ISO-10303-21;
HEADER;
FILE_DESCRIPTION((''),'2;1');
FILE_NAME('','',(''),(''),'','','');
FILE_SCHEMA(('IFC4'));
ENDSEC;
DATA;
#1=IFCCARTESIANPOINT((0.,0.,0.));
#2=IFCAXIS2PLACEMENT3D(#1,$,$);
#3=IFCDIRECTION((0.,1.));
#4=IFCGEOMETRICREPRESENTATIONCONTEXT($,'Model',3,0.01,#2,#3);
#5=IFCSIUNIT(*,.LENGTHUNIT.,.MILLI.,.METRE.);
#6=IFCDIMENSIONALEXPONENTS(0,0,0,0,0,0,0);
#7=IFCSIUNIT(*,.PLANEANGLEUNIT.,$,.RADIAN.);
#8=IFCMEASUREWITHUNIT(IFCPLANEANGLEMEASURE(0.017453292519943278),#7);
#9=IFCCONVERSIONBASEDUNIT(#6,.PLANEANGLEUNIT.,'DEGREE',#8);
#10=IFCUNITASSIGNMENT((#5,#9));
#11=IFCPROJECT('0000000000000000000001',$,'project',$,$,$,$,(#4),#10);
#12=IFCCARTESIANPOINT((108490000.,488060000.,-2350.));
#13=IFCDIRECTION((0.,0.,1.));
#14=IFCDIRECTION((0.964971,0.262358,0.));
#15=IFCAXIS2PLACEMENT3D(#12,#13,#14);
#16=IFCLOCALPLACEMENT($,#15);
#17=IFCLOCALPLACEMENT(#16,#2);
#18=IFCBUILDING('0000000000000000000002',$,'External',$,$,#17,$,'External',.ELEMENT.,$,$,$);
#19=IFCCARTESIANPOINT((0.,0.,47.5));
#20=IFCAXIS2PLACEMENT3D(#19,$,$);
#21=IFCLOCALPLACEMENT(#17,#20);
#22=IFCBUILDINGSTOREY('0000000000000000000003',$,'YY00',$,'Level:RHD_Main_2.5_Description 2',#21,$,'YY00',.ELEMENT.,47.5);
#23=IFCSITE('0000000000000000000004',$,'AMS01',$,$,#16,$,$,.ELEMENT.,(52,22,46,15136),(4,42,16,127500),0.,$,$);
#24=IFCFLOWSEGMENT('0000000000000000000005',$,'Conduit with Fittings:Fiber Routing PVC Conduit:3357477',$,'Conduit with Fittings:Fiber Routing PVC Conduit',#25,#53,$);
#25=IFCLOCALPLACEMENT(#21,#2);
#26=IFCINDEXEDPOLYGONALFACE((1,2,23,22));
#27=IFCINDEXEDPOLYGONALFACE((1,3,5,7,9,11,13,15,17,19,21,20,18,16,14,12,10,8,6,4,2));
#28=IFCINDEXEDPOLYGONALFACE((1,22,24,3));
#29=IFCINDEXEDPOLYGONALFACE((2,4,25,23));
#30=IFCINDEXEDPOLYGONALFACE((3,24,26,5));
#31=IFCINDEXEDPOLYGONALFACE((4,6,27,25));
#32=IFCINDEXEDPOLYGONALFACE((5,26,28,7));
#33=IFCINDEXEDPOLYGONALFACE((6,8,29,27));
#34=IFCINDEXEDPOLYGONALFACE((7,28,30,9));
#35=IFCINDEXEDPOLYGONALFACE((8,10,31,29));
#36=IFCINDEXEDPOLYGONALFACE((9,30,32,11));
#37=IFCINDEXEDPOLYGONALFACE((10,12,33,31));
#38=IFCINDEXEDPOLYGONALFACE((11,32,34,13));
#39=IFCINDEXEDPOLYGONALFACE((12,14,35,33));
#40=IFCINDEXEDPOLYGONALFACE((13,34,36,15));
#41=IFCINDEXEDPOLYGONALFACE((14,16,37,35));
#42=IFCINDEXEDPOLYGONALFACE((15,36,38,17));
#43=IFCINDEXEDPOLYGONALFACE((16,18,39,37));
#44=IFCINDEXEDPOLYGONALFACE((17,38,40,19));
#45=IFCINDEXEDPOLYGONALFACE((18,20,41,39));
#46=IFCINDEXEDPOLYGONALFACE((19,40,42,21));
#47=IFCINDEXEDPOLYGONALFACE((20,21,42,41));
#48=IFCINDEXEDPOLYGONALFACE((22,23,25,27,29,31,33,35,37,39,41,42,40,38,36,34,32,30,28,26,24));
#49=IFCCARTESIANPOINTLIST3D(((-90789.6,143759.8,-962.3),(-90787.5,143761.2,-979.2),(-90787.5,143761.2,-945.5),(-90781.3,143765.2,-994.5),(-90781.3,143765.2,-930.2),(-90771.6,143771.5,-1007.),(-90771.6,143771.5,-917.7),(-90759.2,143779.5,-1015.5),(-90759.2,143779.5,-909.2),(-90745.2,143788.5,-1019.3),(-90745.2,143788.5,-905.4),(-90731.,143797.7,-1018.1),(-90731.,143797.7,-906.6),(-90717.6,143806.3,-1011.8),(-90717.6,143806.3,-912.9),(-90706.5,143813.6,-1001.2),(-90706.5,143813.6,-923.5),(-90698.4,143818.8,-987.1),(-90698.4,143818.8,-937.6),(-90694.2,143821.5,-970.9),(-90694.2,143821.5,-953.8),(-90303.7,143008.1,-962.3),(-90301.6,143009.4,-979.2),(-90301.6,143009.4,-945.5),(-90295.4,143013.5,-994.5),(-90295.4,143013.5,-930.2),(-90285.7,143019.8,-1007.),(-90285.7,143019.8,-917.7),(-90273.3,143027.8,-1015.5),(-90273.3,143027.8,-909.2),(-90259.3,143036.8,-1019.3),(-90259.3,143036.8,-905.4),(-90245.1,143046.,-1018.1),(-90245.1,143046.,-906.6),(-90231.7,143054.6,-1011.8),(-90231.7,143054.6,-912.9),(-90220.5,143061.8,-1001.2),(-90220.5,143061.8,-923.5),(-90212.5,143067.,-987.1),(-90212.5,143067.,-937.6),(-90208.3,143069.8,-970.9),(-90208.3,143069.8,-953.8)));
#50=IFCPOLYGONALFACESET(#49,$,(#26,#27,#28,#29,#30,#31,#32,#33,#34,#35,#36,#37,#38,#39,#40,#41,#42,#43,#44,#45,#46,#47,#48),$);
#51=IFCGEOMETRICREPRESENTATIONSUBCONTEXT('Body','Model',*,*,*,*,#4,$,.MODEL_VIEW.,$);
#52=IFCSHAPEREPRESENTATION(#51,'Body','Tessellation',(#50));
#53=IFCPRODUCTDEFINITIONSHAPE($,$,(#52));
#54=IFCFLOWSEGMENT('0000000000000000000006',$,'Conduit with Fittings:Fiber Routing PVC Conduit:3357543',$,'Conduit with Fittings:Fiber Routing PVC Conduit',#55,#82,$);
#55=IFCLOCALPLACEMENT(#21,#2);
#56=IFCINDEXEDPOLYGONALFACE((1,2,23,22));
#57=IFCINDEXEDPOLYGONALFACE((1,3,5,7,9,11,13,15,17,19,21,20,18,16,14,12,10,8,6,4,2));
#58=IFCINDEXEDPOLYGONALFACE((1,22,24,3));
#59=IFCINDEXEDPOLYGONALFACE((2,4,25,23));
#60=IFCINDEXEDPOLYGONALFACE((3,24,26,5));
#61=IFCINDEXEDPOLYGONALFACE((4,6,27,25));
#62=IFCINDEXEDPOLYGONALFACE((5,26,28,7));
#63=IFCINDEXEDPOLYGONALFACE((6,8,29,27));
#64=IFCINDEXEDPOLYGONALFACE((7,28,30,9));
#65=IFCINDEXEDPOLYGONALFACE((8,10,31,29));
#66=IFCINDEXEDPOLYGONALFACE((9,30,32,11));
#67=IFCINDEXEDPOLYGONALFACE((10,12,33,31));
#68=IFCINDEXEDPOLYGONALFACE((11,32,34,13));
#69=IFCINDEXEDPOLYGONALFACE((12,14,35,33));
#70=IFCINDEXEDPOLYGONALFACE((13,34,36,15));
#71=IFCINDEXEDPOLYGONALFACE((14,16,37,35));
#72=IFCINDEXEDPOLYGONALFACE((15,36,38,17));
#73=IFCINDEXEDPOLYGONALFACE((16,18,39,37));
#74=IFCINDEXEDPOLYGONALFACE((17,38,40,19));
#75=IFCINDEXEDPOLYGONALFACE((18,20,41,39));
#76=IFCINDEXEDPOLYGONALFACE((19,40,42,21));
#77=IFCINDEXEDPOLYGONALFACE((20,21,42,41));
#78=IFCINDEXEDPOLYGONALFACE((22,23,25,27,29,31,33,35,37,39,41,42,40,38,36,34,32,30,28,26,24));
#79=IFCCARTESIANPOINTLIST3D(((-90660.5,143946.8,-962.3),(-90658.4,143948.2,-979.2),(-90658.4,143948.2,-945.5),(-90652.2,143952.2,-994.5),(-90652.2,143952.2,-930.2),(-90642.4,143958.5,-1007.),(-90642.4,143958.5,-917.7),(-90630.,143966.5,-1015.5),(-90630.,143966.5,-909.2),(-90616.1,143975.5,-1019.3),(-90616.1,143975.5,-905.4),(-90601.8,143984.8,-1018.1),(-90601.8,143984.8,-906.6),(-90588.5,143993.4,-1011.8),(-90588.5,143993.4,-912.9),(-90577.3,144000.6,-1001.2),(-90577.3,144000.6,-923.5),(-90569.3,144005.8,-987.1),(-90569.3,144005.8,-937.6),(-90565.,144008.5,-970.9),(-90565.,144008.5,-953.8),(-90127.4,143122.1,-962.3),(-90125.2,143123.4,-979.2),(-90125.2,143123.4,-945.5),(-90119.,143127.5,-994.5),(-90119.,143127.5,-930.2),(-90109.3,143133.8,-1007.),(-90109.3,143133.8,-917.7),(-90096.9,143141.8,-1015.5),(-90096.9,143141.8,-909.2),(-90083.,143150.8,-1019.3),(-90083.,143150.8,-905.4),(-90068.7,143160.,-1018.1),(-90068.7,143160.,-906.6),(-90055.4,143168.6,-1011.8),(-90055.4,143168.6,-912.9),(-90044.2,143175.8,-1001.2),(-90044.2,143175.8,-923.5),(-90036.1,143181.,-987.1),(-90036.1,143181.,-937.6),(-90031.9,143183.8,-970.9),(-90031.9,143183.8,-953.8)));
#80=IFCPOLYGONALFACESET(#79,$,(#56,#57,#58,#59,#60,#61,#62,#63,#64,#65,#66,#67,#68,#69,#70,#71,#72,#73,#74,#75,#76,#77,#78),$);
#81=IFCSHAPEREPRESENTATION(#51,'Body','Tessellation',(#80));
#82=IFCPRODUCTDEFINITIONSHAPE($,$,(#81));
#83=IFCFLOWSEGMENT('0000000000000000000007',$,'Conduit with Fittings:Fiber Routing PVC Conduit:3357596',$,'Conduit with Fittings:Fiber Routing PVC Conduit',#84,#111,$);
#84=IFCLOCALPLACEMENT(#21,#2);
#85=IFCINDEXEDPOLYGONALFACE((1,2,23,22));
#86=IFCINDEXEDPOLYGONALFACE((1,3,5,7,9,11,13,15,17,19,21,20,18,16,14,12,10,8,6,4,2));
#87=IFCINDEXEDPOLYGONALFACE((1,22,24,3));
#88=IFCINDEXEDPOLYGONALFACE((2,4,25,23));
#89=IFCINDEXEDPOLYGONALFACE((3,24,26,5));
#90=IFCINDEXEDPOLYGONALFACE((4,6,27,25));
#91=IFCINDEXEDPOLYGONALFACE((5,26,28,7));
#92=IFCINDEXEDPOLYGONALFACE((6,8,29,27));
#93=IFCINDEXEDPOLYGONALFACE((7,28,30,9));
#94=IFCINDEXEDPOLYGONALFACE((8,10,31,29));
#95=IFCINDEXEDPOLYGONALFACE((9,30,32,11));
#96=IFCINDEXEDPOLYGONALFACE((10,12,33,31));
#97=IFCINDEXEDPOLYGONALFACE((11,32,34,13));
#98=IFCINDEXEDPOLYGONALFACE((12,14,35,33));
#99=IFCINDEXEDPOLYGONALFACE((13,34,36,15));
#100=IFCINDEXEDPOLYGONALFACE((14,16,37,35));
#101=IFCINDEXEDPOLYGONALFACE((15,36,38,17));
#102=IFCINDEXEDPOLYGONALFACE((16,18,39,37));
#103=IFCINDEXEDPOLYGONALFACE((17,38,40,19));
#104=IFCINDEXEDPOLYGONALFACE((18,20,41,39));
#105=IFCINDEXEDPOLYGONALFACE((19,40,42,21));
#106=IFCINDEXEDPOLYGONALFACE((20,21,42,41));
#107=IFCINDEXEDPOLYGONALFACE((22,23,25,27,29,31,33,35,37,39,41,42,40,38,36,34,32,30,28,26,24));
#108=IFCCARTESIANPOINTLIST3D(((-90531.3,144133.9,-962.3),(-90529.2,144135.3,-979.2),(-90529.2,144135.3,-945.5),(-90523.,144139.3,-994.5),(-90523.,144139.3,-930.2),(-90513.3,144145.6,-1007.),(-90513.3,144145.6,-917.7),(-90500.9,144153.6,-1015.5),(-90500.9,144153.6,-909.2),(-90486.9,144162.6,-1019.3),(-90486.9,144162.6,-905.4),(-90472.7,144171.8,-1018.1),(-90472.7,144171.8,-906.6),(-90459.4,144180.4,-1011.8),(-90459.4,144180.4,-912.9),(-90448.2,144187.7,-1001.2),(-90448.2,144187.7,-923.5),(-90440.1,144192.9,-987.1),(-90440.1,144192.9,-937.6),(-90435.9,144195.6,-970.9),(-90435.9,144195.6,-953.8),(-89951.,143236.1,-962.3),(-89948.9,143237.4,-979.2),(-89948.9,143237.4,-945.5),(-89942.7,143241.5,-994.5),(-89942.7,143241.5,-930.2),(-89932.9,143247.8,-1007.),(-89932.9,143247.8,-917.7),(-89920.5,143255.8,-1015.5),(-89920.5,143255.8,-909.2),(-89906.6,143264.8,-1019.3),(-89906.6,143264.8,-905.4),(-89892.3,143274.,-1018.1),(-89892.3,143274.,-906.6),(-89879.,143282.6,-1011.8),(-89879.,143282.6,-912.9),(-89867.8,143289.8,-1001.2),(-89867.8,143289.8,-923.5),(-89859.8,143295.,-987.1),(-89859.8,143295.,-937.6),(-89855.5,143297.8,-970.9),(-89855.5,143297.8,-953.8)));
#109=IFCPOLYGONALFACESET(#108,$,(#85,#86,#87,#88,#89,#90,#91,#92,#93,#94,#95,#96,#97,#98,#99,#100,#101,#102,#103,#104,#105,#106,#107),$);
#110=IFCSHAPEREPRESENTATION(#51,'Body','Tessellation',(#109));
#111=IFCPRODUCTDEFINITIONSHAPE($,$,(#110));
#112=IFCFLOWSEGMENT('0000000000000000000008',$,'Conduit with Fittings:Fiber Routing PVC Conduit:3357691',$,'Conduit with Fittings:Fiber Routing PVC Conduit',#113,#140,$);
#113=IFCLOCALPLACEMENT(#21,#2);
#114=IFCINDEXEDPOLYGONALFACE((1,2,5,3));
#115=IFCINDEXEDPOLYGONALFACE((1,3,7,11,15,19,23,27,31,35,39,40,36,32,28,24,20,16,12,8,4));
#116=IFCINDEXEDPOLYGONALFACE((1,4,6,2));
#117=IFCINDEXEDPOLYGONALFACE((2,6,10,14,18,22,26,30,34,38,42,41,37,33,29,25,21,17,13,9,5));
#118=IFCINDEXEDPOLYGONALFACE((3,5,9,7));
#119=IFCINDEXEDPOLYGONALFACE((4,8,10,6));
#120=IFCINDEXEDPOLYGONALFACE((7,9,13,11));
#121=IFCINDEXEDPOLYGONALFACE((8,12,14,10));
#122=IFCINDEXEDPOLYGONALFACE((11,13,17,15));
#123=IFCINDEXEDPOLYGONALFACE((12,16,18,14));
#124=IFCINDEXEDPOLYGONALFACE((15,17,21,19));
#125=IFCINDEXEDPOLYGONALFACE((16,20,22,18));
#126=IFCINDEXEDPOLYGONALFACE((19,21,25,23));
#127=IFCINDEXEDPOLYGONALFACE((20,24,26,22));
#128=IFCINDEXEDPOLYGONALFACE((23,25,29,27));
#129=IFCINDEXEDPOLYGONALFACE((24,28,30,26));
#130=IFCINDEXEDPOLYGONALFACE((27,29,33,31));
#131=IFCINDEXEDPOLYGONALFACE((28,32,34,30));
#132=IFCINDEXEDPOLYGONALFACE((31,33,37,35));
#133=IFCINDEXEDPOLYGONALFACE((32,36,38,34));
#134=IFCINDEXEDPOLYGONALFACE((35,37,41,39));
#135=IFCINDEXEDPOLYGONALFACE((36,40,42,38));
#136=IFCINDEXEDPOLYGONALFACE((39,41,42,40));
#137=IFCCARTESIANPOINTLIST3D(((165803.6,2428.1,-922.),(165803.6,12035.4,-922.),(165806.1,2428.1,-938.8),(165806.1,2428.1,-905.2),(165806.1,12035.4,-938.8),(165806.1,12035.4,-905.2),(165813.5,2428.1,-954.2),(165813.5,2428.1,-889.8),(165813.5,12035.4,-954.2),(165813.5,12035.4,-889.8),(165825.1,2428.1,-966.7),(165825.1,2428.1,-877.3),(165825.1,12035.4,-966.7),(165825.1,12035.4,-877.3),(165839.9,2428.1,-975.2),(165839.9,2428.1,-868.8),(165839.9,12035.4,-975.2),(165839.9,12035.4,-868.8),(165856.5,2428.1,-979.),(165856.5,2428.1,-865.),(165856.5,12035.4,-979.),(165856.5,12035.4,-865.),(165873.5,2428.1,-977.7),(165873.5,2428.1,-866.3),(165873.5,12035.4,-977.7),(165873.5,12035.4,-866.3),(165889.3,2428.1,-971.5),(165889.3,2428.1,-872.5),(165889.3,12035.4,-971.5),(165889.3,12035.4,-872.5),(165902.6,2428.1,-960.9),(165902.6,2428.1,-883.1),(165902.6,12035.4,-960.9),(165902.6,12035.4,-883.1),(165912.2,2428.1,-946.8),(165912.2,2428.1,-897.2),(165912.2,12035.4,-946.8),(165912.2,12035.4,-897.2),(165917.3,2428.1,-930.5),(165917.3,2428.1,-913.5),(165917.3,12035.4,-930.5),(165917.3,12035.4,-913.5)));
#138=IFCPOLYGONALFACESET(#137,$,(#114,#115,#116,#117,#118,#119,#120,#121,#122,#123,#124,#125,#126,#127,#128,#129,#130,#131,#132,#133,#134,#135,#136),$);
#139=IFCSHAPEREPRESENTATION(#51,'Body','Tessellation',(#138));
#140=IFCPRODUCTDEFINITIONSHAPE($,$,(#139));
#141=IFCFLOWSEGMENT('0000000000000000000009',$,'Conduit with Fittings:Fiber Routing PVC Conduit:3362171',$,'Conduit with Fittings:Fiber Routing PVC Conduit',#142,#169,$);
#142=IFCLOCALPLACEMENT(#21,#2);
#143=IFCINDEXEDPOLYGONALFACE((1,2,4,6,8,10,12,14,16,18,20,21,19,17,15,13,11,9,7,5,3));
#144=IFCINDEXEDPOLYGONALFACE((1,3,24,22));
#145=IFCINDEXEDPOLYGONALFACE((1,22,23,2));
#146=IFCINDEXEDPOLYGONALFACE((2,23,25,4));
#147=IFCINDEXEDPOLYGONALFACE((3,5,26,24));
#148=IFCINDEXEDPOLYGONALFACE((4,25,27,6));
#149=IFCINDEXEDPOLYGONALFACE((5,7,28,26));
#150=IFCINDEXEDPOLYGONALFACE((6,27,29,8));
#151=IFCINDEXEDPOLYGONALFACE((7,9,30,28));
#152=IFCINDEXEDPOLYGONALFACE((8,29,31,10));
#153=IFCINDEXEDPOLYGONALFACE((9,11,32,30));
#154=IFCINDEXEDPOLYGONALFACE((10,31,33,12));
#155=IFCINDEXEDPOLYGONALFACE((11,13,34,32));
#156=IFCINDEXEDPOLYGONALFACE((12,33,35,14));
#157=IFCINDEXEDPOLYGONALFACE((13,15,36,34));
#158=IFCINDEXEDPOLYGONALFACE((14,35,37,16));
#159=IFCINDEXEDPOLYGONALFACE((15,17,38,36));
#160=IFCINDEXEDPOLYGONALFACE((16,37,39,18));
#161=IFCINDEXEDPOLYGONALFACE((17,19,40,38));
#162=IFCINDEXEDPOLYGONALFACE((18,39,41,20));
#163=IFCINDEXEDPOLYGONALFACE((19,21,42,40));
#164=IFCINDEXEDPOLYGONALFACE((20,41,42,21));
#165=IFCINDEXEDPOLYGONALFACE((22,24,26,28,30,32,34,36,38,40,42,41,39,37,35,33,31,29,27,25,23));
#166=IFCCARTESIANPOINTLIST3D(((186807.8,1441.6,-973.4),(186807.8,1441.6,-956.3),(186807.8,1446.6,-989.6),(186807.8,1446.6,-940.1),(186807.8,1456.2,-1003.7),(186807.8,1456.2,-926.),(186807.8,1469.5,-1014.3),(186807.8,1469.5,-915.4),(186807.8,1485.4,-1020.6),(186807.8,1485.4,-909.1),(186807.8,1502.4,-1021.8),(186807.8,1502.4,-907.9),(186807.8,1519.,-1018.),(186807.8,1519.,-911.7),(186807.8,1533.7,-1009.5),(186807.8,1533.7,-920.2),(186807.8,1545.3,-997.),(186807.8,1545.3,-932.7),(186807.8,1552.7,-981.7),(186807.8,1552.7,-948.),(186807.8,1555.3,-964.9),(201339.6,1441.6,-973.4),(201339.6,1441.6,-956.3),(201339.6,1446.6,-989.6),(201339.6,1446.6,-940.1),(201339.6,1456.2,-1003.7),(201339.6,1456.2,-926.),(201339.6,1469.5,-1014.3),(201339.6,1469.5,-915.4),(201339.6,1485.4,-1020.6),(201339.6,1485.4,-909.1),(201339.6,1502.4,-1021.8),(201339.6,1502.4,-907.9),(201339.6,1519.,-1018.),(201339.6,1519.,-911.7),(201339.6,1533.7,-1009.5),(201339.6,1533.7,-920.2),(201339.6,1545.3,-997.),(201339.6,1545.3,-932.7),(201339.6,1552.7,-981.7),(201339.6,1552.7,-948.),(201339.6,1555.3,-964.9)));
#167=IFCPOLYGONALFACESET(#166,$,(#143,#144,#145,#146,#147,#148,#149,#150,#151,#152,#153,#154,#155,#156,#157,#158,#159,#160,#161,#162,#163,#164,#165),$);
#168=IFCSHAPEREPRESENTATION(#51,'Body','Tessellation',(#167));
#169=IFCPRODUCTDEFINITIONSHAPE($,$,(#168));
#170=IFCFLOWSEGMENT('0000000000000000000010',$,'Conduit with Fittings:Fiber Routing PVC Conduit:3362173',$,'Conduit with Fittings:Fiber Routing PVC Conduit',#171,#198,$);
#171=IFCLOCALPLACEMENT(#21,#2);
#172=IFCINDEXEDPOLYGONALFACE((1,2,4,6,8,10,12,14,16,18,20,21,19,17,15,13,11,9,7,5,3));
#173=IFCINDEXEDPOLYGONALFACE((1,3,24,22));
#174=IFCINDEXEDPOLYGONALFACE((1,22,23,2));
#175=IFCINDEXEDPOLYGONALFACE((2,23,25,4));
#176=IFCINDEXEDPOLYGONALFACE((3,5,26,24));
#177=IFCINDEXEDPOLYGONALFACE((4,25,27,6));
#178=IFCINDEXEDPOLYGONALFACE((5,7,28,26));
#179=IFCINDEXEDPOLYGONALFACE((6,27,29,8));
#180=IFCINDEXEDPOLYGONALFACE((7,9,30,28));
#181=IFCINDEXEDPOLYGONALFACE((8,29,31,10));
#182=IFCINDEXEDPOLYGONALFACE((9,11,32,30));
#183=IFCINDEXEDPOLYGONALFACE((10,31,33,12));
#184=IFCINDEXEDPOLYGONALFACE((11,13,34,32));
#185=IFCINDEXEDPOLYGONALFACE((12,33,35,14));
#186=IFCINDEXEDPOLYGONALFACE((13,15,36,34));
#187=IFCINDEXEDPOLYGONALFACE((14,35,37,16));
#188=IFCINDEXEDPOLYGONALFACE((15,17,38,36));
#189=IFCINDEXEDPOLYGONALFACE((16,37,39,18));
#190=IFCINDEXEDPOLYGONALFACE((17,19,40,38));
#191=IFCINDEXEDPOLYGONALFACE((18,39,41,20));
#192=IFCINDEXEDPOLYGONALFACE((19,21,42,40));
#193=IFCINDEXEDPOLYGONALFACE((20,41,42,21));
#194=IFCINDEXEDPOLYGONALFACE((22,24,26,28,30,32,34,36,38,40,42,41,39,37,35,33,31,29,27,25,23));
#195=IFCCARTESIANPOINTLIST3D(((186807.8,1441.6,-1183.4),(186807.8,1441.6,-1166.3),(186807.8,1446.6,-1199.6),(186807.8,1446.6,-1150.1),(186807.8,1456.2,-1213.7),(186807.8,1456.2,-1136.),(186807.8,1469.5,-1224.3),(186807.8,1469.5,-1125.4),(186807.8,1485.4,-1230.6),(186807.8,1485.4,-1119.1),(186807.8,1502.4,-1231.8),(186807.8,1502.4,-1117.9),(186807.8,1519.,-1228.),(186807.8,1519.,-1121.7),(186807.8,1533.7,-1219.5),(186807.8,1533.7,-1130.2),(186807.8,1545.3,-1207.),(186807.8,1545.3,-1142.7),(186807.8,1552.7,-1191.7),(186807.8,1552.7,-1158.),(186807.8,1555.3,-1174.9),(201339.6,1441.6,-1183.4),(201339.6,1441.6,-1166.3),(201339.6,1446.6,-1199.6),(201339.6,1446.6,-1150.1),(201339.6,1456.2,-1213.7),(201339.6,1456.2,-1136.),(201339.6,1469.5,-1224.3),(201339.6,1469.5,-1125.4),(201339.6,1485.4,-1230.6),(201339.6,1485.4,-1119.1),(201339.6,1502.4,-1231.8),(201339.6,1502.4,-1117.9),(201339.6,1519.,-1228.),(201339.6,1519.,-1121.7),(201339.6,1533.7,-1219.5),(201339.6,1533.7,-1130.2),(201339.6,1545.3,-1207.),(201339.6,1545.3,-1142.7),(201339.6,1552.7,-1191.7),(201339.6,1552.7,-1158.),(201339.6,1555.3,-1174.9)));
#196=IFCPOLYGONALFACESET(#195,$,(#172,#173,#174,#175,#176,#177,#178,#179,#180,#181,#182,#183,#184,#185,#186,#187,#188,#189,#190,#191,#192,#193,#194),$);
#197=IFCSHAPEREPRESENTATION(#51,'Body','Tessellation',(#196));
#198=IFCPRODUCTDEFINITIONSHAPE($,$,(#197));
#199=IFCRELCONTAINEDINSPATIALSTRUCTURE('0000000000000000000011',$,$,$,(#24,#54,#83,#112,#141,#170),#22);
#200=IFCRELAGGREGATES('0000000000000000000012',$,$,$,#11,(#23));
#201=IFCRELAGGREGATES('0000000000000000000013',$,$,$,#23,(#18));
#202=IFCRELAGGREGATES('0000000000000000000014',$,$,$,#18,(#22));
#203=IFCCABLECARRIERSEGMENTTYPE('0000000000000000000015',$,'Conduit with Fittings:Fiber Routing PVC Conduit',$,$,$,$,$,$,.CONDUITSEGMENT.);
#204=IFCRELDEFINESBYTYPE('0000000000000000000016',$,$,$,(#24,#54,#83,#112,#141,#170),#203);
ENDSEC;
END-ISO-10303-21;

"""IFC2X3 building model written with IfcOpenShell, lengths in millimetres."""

from ifc_helpers import new_model, entity, si_unit, converted_unit, direction, frame, frame_2d, origin, place, context, subcontext, project, spatial, circle, extrude, type_object, element, save


model = new_model("IFC2X3")

# Units and contexts
model_context = context("Model", 3, precision=0.01, world=origin(), true_north=direction((0.0, 1.0)))
body_context = subcontext(model_context, "Body", "Model", "MODEL_VIEW")
ifc_project = project(units=[si_unit("LENGTHUNIT", "METRE", prefix="MILLI"), converted_unit("PLANEANGLEUNIT", "DEGREE", entity("IfcPlaneAngleMeasure", 0.017453292519943278), si_unit("PLANEANGLEUNIT", "RADIAN"), dimensions=[0, 0, 0, 0, 0, 0, 0])], contexts=[model_context])

# Site, building, storey
site_placement = place(None, frame((108490000.0, 488060000.0, -2350.0), z_axis=(0.0, 0.0, 1.0), x_axis=(0.964971, 0.262358, 0.0)))
site = spatial("IfcSite", under=ifc_project, at=site_placement, Name="AMS01", CompositionType="ELEMENT", RefLatitude=(52, 22, 46, 15136), RefLongitude=(4, 42, 16, 127500), RefElevation=0.0)
building_placement = place(site_placement, origin())
building = spatial("IfcBuilding", under=site, at=building_placement, Name="External", LongName="External", CompositionType="ELEMENT")
storey_placement = place(building_placement, frame((0.0, 0.0, 47.5)))
storey = spatial("IfcBuildingStorey", under=building, at=storey_placement, Name="YY00", ObjectType="Level:RHD_Main_2.5_Description 2", LongName="YY00", CompositionType="ELEMENT", Elevation=47.5)

# Flow segments
cable_carrier_segment_type = type_object("IfcCableCarrierSegmentType", Name="Conduit with Fittings:Fiber Routing PVC Conduit", PredefinedType="CONDUITSEGMENT")
flow_segment_1_placement = place(storey_placement, origin())
element("IfcFlowSegment", 1, at=flow_segment_1_placement, inside=storey, type_object=cable_carrier_segment_type, Name="Conduit with Fittings:Fiber Routing PVC Conduit:3357477", ObjectType="Conduit with Fittings:Fiber Routing PVC Conduit", context=body_context, shape_type="SweptSolid", body=[
    extrude(circle(Radius=57.2, at=frame_2d((0.0, 0.0), x_axis=(1.0, 0.0))), frame((-90741.6, 143790.8, -962.3), z_axis=(0.542856, -0.839826, 0.0), x_axis=(-0.839826, -0.542856, 0.0)), (0.0, 0.0, 1.0), 895.1),
])
flow_segment_2_placement = place(storey_placement, origin())
element("IfcFlowSegment", 2, at=flow_segment_2_placement, inside=storey, type_object=cable_carrier_segment_type, Name="Conduit with Fittings:Fiber Routing PVC Conduit:3357543", ObjectType="Conduit with Fittings:Fiber Routing PVC Conduit", context=body_context, shape_type="SweptSolid", body=[
    extrude(circle(Radius=57.2, at=frame_2d((0.0, 0.0), x_axis=(1.0, 0.0))), frame((-90612.5, 143977.9, -962.3), z_axis=(0.542856, -0.839826, 0.0), x_axis=(-0.839826, -0.542856, 0.0)), (0.0, 0.0, 1.0), 982.1),
])
flow_segment_3_placement = place(storey_placement, origin())
element("IfcFlowSegment", 3, at=flow_segment_3_placement, inside=storey, type_object=cable_carrier_segment_type, Name="Conduit with Fittings:Fiber Routing PVC Conduit:3357596", ObjectType="Conduit with Fittings:Fiber Routing PVC Conduit", context=body_context, shape_type="SweptSolid", body=[
    extrude(circle(Radius=57.2, at=frame_2d((0.0, 0.0), x_axis=(1.0, 0.0))), frame((-90483.4, 144164.9, -962.3), z_axis=(0.542856, -0.839826, 0.0), x_axis=(-0.839826, -0.542856, 0.0)), (0.0, 0.0, 1.0), 1069.1),
])
flow_segment_4_placement = place(storey_placement, origin())
element("IfcFlowSegment", 4, at=flow_segment_4_placement, inside=storey, type_object=cable_carrier_segment_type, Name="Conduit with Fittings:Fiber Routing PVC Conduit:3357691", ObjectType="Conduit with Fittings:Fiber Routing PVC Conduit", context=body_context, shape_type="SweptSolid", body=[
    extrude(circle(Radius=57.2, at=frame_2d((0.0, 0.0), x_axis=(1.0, 0.0))), frame((165860.7, 2428.1, -922.0), z_axis=(0.0, 1.0, 0.0), x_axis=(-1.0, 0.0, 0.0)), (0.0, 0.0, 1.0), 9607.3),
])
flow_segment_5_placement = place(storey_placement, origin())
element("IfcFlowSegment", 5, at=flow_segment_5_placement, inside=storey, type_object=cable_carrier_segment_type, Name="Conduit with Fittings:Fiber Routing PVC Conduit:3362171", ObjectType="Conduit with Fittings:Fiber Routing PVC Conduit", context=body_context, shape_type="SweptSolid", body=[
    extrude(circle(Radius=57.2, at=frame_2d((0.0, 0.0), x_axis=(1.0, 0.0))), frame((186807.8, 1498.1, -964.9), z_axis=(1.0, 0.0, 0.0), x_axis=(0.0, 1.0, 0.0)), (0.0, 0.0, 1.0), 14531.7),
])
flow_segment_6_placement = place(storey_placement, origin())
element("IfcFlowSegment", 6, at=flow_segment_6_placement, inside=storey, type_object=cable_carrier_segment_type, Name="Conduit with Fittings:Fiber Routing PVC Conduit:3362173", ObjectType="Conduit with Fittings:Fiber Routing PVC Conduit", context=body_context, shape_type="SweptSolid", body=[
    extrude(circle(Radius=57.2, at=frame_2d((0.0, 0.0), x_axis=(1.0, 0.0))), frame((186807.8, 1498.1, -1174.9), z_axis=(1.0, 0.0, 0.0), x_axis=(0.0, 1.0, 0.0)), (0.0, 0.0, 1.0), 14531.7),
])

save(model, "model.ifc")
